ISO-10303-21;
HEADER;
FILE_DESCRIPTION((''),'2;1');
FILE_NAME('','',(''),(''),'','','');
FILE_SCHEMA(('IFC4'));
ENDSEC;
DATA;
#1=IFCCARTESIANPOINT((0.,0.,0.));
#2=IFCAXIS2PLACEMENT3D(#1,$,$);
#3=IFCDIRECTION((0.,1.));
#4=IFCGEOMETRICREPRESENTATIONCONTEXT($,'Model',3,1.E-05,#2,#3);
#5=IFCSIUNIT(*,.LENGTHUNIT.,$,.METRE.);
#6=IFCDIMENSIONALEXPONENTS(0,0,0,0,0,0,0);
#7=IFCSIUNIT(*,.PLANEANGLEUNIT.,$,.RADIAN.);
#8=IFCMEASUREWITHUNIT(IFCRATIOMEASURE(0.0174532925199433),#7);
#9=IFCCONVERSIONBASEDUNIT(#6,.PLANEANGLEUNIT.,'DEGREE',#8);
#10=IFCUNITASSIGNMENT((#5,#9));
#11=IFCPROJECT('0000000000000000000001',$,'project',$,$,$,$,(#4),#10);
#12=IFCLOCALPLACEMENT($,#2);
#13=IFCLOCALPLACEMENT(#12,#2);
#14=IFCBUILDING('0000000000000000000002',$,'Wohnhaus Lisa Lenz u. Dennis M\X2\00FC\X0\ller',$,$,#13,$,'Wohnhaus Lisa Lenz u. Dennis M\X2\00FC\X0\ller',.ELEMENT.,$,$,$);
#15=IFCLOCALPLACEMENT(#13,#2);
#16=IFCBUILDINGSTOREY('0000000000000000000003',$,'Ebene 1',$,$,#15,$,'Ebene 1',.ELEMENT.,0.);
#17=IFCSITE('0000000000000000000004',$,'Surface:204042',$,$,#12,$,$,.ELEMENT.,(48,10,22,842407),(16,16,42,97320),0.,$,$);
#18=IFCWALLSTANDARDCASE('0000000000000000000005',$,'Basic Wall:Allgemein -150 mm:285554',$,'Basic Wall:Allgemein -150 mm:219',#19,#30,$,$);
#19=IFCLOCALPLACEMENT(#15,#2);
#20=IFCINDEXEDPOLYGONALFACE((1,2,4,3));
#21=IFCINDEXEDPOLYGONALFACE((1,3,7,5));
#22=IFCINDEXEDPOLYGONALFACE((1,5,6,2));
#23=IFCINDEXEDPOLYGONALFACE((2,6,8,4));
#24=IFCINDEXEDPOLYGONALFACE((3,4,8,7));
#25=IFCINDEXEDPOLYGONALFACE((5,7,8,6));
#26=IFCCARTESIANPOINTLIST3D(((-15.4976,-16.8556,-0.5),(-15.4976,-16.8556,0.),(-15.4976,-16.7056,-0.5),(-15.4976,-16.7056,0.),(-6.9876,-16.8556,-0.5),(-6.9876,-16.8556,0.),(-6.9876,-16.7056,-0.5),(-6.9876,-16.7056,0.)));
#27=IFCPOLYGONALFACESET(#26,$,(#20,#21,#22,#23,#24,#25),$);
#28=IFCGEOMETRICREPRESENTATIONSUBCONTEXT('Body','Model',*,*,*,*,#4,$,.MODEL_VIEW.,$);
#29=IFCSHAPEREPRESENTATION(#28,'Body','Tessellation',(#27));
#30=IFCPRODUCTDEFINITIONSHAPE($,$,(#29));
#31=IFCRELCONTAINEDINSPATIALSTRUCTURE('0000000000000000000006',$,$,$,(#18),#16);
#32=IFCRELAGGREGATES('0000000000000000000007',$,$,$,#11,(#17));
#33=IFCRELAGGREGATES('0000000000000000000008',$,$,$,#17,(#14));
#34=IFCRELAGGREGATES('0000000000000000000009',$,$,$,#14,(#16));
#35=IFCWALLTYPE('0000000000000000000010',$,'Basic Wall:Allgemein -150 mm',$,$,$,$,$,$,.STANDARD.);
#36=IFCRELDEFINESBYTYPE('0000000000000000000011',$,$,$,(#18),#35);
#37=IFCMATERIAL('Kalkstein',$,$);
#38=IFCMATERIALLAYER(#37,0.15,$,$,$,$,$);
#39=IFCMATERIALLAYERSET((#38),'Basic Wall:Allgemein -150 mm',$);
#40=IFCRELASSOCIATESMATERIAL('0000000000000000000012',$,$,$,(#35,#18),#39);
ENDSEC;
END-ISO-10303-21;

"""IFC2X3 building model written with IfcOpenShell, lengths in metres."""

from ifc_helpers import new_model, entity, si_unit, converted_unit, direction, frame, frame_2d, origin, place, context, subcontext, project, spatial, rectangle, extrude, material, layer, layer_set, layer_usage, type_object, element, save


model = new_model("IFC2X3")

# Units and contexts
model_context = context("Model", 3, precision=1e-05, world=origin(), true_north=direction((0.0, 1.0)))
body_context = subcontext(model_context, "Body", "Model", "MODEL_VIEW")
ifc_project = project(units=[si_unit("LENGTHUNIT", "METRE"), converted_unit("PLANEANGLEUNIT", "DEGREE", entity("IfcRatioMeasure", 0.0174532925199433), si_unit("PLANEANGLEUNIT", "RADIAN"), dimensions=[0, 0, 0, 0, 0, 0, 0])], contexts=[model_context])

# Site, building, storey
site_placement = place(None, origin())
site = spatial("IfcSite", under=ifc_project, at=site_placement, Name="Surface:204042", CompositionType="ELEMENT", RefLatitude=(48, 10, 22, 842407), RefLongitude=(16, 16, 42, 97320), RefElevation=0.0)
building_placement = place(site_placement, origin())
building = spatial("IfcBuilding", under=site, at=building_placement, Name="Wohnhaus Lisa Lenz u. Dennis Müller", LongName="Wohnhaus Lisa Lenz u. Dennis Müller", CompositionType="ELEMENT")
storey_placement = place(building_placement, origin())
storey = spatial("IfcBuildingStorey", under=building, at=storey_placement, Name="Ebene 1", LongName="Ebene 1", CompositionType="ELEMENT", Elevation=0.0)

# Shared definitions
ifc_material_1 = material(Name="Kalkstein")

# Wall
ifc_layer_1 = layer(ifc_material_1, 0.15)
ifc_layer_set_1 = layer_set([ifc_layer_1], Name="Basic Wall:Allgemein -150 mm")
ifc_layer_usage_1 = layer_usage(ifc_layer_set_1, "AXIS2", "NEGATIVE", 0.075)
wall_type_1 = type_object("IfcWallType", Name="Basic Wall:Allgemein -150 mm", PredefinedType="STANDARD", material=ifc_layer_set_1)
wall_1_placement = place(storey_placement, frame((-15.4976, -16.7806, -0.5)))
element("IfcWallStandardCase", 1, at=wall_1_placement, inside=storey, type_object=wall_type_1, material=ifc_layer_usage_1, Name="Basic Wall:Allgemein -150 mm:285554", ObjectType="Basic Wall:Allgemein -150 mm:219", context=body_context, shape_type="SweptSolid", body=[
    extrude(rectangle(XDim=8.51, YDim=0.15, at=frame_2d((4.255, 0.0), x_axis=(-1.0, 0.0))), origin(), (0.0, 0.0, 1.0), 0.5),
])

save(model, "model.ifc")
